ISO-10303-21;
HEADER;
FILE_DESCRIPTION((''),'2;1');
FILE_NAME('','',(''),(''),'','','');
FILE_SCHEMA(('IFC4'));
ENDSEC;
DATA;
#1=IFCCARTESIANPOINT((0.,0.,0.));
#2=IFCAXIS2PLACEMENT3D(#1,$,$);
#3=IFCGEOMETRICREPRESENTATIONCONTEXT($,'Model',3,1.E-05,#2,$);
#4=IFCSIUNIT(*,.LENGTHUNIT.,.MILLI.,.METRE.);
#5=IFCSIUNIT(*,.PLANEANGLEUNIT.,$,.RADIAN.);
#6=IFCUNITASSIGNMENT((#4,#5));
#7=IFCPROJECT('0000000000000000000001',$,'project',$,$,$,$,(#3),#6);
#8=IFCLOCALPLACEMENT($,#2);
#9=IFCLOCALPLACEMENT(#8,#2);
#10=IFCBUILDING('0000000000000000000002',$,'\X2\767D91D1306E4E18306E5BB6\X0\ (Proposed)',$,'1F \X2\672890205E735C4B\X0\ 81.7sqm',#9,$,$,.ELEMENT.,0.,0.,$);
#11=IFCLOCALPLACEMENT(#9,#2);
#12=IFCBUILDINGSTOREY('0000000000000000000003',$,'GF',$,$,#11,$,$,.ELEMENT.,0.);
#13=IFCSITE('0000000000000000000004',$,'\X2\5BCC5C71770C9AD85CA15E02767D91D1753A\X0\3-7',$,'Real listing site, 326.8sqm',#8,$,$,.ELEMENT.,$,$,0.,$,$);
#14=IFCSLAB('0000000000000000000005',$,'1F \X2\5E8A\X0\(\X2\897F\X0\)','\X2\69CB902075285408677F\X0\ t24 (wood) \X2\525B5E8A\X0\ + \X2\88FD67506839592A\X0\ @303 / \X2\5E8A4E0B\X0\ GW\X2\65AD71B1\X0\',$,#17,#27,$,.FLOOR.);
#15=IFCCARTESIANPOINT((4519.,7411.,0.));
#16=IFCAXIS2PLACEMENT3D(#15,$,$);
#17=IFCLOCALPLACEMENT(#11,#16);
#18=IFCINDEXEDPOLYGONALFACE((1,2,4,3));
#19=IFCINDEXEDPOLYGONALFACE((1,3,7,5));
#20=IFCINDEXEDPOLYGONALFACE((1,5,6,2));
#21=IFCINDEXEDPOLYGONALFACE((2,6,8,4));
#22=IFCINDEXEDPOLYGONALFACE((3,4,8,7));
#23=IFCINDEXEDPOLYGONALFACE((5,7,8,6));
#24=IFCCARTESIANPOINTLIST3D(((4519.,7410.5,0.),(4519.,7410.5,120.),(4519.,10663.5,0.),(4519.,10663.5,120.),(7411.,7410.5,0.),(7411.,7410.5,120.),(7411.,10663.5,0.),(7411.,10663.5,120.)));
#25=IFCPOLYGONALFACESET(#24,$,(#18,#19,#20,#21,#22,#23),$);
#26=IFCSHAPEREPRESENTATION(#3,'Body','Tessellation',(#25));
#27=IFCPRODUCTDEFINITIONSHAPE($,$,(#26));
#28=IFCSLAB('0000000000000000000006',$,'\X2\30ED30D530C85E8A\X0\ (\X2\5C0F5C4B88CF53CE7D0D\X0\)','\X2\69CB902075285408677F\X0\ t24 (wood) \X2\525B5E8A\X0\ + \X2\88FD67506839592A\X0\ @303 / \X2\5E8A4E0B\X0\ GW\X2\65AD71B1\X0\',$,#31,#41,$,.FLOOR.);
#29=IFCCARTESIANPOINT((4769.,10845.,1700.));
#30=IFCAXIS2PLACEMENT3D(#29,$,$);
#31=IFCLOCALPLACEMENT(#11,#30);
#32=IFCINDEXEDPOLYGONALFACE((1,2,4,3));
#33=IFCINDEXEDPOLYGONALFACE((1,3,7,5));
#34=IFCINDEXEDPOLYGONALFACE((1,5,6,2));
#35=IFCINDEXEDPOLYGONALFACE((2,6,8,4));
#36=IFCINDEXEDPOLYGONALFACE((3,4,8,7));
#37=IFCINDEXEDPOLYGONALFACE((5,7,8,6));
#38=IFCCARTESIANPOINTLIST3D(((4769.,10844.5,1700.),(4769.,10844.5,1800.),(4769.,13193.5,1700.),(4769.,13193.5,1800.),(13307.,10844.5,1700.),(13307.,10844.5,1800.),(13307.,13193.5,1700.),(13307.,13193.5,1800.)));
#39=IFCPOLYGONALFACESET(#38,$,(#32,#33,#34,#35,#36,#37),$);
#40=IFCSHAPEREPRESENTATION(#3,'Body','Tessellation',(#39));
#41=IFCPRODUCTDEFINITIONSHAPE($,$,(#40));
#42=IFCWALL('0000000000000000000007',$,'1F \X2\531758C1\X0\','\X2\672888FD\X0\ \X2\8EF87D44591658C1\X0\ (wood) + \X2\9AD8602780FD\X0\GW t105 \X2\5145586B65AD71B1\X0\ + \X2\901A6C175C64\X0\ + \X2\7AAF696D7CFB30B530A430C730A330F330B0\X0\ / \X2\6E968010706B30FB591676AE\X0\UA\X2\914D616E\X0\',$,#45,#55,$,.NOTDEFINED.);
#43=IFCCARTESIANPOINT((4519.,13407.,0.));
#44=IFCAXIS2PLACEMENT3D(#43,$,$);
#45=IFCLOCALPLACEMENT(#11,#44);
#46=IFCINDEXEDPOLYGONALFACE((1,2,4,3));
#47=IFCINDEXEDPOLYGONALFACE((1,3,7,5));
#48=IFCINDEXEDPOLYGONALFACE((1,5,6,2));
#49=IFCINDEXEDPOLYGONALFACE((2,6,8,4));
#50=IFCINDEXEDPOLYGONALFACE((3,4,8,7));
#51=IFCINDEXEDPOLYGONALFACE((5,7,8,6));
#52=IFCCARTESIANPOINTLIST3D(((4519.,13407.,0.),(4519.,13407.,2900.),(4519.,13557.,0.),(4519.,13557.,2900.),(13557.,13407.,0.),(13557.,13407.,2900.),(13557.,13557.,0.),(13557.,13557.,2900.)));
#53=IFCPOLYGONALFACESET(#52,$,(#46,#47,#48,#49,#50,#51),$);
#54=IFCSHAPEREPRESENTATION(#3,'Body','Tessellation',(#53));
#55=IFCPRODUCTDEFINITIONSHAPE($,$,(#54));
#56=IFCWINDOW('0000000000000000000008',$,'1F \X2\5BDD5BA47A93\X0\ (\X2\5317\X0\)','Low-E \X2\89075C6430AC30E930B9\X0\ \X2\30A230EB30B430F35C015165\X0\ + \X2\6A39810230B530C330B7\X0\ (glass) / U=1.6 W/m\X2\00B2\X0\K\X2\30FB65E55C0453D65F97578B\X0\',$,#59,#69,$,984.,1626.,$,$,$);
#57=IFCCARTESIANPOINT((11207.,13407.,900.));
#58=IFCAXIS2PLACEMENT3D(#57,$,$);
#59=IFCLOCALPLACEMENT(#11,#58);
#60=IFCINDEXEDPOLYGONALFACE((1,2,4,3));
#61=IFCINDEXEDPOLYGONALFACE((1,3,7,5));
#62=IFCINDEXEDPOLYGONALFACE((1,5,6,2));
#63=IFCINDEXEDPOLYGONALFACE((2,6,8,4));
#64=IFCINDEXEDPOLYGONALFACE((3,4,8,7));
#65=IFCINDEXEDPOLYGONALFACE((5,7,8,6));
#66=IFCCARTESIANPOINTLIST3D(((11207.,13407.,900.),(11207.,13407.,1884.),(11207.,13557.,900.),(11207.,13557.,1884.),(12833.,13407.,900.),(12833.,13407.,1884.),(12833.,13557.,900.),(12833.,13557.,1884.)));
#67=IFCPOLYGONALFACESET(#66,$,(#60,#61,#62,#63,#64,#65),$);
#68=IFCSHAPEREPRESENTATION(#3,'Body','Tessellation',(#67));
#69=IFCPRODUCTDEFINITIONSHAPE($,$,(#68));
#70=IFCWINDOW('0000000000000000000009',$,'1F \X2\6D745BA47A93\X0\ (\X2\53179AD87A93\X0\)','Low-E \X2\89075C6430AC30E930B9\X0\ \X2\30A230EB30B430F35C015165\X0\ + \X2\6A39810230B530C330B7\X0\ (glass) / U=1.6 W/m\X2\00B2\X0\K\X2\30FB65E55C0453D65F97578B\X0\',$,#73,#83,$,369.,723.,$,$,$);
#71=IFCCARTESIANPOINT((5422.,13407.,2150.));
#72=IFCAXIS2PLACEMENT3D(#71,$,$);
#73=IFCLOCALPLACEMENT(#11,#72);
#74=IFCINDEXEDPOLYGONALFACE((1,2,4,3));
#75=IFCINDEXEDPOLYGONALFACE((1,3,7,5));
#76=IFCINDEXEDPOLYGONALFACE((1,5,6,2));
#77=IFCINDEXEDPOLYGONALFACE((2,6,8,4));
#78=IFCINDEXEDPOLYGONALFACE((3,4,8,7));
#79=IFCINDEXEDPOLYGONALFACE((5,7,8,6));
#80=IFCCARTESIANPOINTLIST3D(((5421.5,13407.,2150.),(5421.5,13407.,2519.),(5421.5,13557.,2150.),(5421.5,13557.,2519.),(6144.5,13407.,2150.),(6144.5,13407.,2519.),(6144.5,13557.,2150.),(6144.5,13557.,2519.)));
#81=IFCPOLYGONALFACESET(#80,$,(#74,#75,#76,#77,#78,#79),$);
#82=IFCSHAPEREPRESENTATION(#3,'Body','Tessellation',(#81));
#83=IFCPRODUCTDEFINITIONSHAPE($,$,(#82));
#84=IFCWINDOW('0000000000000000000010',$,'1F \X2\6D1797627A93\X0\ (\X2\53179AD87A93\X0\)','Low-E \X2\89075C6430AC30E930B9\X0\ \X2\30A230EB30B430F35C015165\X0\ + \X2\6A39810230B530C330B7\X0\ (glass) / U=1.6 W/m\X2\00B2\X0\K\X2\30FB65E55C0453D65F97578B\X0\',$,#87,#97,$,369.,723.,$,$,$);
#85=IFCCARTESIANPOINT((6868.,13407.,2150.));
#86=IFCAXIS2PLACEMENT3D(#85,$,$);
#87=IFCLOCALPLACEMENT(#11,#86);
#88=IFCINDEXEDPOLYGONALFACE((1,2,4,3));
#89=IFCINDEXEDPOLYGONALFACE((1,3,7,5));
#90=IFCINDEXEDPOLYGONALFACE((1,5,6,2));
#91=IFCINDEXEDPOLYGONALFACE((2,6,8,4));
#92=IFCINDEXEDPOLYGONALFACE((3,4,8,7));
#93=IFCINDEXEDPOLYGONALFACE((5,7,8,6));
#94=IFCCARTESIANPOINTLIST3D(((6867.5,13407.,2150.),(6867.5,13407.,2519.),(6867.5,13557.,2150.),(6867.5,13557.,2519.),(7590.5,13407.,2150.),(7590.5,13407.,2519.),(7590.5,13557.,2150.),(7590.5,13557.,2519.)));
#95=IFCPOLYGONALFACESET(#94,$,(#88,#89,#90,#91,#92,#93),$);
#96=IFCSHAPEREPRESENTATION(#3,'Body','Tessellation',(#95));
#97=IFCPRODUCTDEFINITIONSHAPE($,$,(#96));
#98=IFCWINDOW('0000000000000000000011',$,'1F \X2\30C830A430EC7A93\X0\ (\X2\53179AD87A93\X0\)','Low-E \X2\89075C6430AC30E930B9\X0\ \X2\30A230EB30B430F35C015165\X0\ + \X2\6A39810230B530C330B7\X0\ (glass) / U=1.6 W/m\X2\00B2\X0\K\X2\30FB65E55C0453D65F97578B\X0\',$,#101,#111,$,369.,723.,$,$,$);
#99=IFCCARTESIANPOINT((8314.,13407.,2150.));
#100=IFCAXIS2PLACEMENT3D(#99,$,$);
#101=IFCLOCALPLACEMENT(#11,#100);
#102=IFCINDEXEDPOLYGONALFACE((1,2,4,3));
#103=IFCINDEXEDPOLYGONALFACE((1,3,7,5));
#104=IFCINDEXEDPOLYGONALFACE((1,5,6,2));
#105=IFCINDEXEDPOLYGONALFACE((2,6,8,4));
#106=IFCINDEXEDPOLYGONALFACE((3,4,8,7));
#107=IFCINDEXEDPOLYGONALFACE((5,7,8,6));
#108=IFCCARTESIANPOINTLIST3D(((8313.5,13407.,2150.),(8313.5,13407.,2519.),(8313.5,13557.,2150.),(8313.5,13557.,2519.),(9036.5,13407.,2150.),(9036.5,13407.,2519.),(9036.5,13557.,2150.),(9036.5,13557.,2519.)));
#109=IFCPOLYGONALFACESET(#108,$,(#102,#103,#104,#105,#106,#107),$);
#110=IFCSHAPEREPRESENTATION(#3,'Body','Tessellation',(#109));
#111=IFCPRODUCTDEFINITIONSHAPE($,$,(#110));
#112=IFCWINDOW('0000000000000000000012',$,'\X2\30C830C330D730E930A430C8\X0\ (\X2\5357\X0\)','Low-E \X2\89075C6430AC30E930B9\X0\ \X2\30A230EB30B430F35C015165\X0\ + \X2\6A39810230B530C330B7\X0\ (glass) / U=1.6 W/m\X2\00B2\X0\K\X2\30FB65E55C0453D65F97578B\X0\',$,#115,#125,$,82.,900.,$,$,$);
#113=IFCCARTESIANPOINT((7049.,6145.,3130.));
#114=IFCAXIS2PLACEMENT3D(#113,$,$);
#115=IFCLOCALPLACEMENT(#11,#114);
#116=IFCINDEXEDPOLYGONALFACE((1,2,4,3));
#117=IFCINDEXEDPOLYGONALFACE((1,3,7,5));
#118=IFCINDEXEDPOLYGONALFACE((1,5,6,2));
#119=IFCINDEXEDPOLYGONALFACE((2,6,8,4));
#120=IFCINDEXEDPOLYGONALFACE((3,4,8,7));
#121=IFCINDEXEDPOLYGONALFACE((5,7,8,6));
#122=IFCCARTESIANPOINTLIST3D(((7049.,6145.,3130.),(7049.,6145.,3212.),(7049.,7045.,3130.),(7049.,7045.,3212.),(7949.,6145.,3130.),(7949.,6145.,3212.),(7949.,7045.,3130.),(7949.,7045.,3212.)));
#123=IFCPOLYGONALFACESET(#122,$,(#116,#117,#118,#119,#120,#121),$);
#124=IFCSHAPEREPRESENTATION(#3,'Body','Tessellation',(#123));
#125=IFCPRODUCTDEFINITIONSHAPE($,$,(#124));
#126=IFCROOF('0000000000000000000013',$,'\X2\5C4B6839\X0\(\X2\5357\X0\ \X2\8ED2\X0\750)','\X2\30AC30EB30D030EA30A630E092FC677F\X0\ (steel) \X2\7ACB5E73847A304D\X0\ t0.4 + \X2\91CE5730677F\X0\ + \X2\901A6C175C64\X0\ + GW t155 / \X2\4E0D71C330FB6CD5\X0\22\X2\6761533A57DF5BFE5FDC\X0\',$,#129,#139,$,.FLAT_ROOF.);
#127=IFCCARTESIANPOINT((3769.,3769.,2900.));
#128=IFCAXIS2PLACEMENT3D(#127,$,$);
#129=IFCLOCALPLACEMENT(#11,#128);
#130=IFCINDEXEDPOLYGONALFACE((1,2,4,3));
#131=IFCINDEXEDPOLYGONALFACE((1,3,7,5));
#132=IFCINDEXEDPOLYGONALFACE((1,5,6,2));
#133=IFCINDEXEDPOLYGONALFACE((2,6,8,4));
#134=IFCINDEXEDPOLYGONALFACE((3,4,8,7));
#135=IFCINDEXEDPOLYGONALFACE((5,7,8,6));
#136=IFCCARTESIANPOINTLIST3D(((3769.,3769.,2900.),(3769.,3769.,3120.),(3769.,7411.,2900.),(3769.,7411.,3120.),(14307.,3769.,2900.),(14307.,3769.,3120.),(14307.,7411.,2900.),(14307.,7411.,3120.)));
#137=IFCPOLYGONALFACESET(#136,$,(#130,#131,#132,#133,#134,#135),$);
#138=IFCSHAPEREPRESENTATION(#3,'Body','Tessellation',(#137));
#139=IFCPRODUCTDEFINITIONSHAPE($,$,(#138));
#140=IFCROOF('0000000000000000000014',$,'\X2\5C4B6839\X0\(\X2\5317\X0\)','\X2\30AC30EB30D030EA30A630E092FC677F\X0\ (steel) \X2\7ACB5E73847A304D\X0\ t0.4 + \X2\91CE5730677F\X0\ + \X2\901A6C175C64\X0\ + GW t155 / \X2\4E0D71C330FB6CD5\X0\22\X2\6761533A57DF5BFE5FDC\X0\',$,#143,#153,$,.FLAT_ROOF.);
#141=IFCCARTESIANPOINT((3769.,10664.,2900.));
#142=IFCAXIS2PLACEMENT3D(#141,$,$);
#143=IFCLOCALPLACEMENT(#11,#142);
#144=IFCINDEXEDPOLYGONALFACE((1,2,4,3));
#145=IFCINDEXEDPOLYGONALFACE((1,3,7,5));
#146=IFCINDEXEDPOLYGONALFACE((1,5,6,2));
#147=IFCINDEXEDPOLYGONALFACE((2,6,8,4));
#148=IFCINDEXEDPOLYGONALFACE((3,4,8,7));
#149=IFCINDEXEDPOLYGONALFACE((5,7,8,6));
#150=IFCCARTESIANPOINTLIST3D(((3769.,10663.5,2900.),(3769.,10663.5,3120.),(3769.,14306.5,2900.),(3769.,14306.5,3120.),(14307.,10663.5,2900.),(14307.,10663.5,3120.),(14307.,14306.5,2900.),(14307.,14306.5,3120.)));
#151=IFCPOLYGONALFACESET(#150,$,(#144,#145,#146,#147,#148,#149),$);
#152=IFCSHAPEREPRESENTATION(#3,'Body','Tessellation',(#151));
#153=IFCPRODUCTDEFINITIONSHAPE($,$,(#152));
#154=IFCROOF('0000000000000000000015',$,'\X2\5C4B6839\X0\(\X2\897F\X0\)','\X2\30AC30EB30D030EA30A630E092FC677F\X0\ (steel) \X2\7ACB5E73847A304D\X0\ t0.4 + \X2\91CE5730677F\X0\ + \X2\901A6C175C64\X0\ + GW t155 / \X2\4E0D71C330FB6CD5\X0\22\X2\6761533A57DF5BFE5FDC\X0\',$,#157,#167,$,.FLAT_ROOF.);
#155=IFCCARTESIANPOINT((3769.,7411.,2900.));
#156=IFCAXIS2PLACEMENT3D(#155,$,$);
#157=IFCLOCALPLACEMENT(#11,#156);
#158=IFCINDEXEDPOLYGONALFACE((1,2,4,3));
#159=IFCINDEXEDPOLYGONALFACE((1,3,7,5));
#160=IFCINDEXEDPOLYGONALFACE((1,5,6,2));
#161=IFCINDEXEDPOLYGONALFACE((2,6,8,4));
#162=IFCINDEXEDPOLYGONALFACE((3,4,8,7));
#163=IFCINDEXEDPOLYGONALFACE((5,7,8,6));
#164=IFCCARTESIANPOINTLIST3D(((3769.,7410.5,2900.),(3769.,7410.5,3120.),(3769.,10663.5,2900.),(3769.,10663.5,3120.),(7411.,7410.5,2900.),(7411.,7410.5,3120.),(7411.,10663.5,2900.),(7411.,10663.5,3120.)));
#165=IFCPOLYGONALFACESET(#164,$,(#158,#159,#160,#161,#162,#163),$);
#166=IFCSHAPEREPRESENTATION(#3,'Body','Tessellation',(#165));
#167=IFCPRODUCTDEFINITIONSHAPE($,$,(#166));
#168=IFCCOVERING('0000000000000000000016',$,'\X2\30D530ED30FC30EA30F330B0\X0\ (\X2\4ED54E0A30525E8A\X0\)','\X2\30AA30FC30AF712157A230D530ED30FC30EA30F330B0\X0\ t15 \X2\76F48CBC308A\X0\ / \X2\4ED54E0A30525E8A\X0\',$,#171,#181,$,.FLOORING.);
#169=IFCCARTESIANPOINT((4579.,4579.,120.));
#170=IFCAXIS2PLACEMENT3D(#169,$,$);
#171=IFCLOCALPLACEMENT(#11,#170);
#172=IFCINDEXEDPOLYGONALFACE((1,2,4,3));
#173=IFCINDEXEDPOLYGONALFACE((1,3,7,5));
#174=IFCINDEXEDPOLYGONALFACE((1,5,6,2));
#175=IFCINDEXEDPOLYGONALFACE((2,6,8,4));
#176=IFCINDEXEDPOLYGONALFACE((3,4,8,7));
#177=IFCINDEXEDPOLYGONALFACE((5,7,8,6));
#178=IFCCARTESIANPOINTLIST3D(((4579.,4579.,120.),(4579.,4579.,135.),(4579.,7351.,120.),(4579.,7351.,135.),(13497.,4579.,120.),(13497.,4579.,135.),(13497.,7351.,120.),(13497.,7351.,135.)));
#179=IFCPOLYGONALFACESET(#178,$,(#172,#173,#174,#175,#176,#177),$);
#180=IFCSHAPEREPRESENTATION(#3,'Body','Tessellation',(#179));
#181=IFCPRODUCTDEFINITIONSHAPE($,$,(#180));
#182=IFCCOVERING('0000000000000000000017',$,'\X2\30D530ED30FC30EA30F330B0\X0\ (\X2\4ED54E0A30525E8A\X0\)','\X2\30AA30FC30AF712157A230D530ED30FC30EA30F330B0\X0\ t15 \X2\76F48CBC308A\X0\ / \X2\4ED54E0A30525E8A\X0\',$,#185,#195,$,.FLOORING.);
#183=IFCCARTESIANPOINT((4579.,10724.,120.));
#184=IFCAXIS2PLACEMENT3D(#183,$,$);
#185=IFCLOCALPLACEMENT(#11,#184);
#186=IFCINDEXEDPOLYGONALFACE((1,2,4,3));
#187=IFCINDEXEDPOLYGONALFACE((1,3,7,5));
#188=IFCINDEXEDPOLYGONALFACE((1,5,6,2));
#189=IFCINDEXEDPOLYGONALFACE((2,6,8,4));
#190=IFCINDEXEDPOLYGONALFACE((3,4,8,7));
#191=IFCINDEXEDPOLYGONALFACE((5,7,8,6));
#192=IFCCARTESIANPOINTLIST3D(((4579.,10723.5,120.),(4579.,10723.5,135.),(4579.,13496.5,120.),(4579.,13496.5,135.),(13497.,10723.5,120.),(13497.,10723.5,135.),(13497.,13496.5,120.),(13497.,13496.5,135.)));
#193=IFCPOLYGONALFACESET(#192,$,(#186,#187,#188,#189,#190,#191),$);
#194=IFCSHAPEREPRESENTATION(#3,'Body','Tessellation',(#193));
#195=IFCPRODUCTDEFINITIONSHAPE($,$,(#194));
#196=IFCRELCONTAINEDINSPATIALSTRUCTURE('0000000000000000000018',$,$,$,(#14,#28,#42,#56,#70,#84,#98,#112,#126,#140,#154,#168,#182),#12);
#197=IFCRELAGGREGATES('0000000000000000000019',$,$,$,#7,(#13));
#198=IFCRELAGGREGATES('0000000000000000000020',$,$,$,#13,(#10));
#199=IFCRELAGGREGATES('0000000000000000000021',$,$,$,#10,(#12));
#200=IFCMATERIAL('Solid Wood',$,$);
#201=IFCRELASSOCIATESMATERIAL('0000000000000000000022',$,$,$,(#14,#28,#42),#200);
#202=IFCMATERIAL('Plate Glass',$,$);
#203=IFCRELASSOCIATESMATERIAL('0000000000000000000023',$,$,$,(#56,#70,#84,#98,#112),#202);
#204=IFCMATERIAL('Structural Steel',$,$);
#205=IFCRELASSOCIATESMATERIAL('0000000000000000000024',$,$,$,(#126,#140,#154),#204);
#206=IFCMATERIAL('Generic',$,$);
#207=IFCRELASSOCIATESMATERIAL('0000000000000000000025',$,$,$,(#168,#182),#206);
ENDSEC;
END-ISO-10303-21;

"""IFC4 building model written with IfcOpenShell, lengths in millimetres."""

from ifc_helpers import new_model, si_unit, frame, frame_2d, origin, place, context, project, spatial, rectangle, extrude, material, element, fill, save


model = new_model("IFC4")

# Units and contexts
model_context = context("Model", 3, precision=1e-05, world=origin())
ifc_project = project(units=[si_unit("LENGTHUNIT", "METRE", prefix="MILLI"), si_unit("PLANEANGLEUNIT", "RADIAN")], contexts=[model_context])

# Site, building, storey
site_placement = place(None, origin())
site = spatial("IfcSite", under=ifc_project, at=site_placement, Name="富山県高岡市白金町3-7", ObjectType="Real listing site, 326.8sqm", CompositionType="ELEMENT", RefElevation=0.0)
building_placement = place(site_placement, origin())
building = spatial("IfcBuilding", under=site, at=building_placement, Name="白金の丘の家 (Proposed)", ObjectType="1F 木造平屋 81.7sqm", CompositionType="ELEMENT", ElevationOfRefHeight=0.0, ElevationOfTerrain=0.0)
storey_placement = place(building_placement, origin())
storey = spatial("IfcBuildingStorey", under=building, at=storey_placement, Name="GF", CompositionType="ELEMENT", Elevation=0.0)

# Slabs
ifc_material_1 = material(Name="Solid Wood")
slab_1_placement = place(storey_placement, frame((4519.0, 7411.0, 0.0)))
element("IfcSlab", 1, at=slab_1_placement, inside=storey, material=ifc_material_1, Name="1F 床(西)", Description="構造用合板 t24 (wood) 剛床 + 製材根太 @303 / 床下 GW断熱", PredefinedType="FLOOR", context=model_context, shape_type="SweptSolid", body=[
    extrude(rectangle(XDim=2892.0, YDim=3253.0, at=frame_2d((1446.0, 1626.0))), frame((4519.0, 7411.0, 0.0)), (0.0, 0.0, 1.0), 120.0),
])
slab_2_placement = place(storey_placement, frame((4769.0, 10845.0, 1700.0)))
element("IfcSlab", 2, at=slab_2_placement, inside=storey, material=ifc_material_1, Name="ロフト床 (小屋裏収納)", Description="構造用合板 t24 (wood) 剛床 + 製材根太 @303 / 床下 GW断熱", PredefinedType="FLOOR", context=model_context, shape_type="SweptSolid", body=[
    extrude(rectangle(XDim=8538.0, YDim=2349.0, at=frame_2d((4269.0, 1174.0))), frame((4769.0, 10845.0, 1700.0)), (0.0, 0.0, 1.0), 100.0),
])

# Shared definitions
ifc_material_2 = material(Name="Plate Glass")

# Wall, openings, windows
wall_1_placement = place(storey_placement, frame((4519.0, 13407.0, 0.0)))
wall_1 = element("IfcWall", 3, at=wall_1_placement, inside=storey, material=ifc_material_1, Name="1F 北壁", Description="木製 軸組外壁 (wood) + 高性能GW t105 充填断熱 + 通気層 + 窯業系サイディング / 準耐火・外皮UA配慮", PredefinedType="NOTDEFINED", context=model_context, shape_type="SweptSolid", body=[
    extrude(rectangle(XDim=9038.0, YDim=150.0, at=frame_2d((4519.0, 75.0))), frame((4519.0, 13407.0, 0.0)), (0.0, 0.0, 1.0), 2900.0),
])
opening_1_placement = place(storey_placement, frame((11207.0, 13407.0, 900.0)))
opening_1 = element("IfcOpeningElement", 4, at=opening_1_placement, cuts=wall_1, PredefinedType="NOTDEFINED", context=model_context, shape_type="SweptSolid", body=[
    extrude(rectangle(XDim=1626.0, YDim=150.0, at=frame_2d((813.0, 75.0))), frame((11207.0, 13407.0, 900.0)), (0.0, 0.0, 1.0), 984.0),
])
opening_2_placement = place(storey_placement, frame((5422.0, 13407.0, 2150.0)))
opening_2 = element("IfcOpeningElement", 5, at=opening_2_placement, cuts=wall_1, PredefinedType="NOTDEFINED", context=model_context, shape_type="SweptSolid", body=[
    extrude(rectangle(XDim=723.0, YDim=150.0, at=frame_2d((361.0, 75.0))), frame((5422.0, 13407.0, 2150.0)), (0.0, 0.0, 1.0), 369.0),
])
opening_3_placement = place(storey_placement, frame((6868.0, 13407.0, 2150.0)))
opening_3 = element("IfcOpeningElement", 6, at=opening_3_placement, cuts=wall_1, PredefinedType="NOTDEFINED", context=model_context, shape_type="SweptSolid", body=[
    extrude(rectangle(XDim=723.0, YDim=150.0, at=frame_2d((361.0, 75.0))), frame((6868.0, 13407.0, 2150.0)), (0.0, 0.0, 1.0), 369.0),
])
opening_4_placement = place(storey_placement, frame((8314.0, 13407.0, 2150.0)))
opening_4 = element("IfcOpeningElement", 7, at=opening_4_placement, cuts=wall_1, PredefinedType="NOTDEFINED", context=model_context, shape_type="SweptSolid", body=[
    extrude(rectangle(XDim=723.0, YDim=150.0, at=frame_2d((361.0, 75.0))), frame((8314.0, 13407.0, 2150.0)), (0.0, 0.0, 1.0), 369.0),
])
window_1_placement = place(storey_placement, frame((11207.0, 13407.0, 900.0)))
window_1 = element("IfcWindow", 8, at=window_1_placement, inside=storey, material=ifc_material_2, Name="1F 寝室窓 (北)", Description="Low-E 複層ガラス アルゴン封入 + 樹脂サッシ (glass) / U=1.6 W/m²K・日射取得型", OverallHeight=984.0, OverallWidth=1626.0, context=model_context, shape_type="SweptSolid", body=[
    extrude(rectangle(XDim=1626.0, YDim=150.0, at=frame_2d((813.0, 75.0))), frame((11207.0, 13407.0, 900.0)), (0.0, 0.0, 1.0), 984.0),
])
fill(opening_1, window_1)
window_2_placement = place(storey_placement, frame((5422.0, 13407.0, 2150.0)))
window_2 = element("IfcWindow", 9, at=window_2_placement, inside=storey, material=ifc_material_2, Name="1F 浴室窓 (北高窓)", Description="Low-E 複層ガラス アルゴン封入 + 樹脂サッシ (glass) / U=1.6 W/m²K・日射取得型", OverallHeight=369.0, OverallWidth=723.0, context=model_context, shape_type="SweptSolid", body=[
    extrude(rectangle(XDim=723.0, YDim=150.0, at=frame_2d((361.0, 75.0))), frame((5422.0, 13407.0, 2150.0)), (0.0, 0.0, 1.0), 369.0),
])
fill(opening_2, window_2)
window_3_placement = place(storey_placement, frame((6868.0, 13407.0, 2150.0)))
window_3 = element("IfcWindow", 10, at=window_3_placement, inside=storey, material=ifc_material_2, Name="1F 洗面窓 (北高窓)", Description="Low-E 複層ガラス アルゴン封入 + 樹脂サッシ (glass) / U=1.6 W/m²K・日射取得型", OverallHeight=369.0, OverallWidth=723.0, context=model_context, shape_type="SweptSolid", body=[
    extrude(rectangle(XDim=723.0, YDim=150.0, at=frame_2d((361.0, 75.0))), frame((6868.0, 13407.0, 2150.0)), (0.0, 0.0, 1.0), 369.0),
])
fill(opening_3, window_3)
window_4_placement = place(storey_placement, frame((8314.0, 13407.0, 2150.0)))
window_4 = element("IfcWindow", 11, at=window_4_placement, inside=storey, material=ifc_material_2, Name="1F トイレ窓 (北高窓)", Description="Low-E 複層ガラス アルゴン封入 + 樹脂サッシ (glass) / U=1.6 W/m²K・日射取得型", OverallHeight=369.0, OverallWidth=723.0, context=model_context, shape_type="SweptSolid", body=[
    extrude(rectangle(XDim=723.0, YDim=150.0, at=frame_2d((361.0, 75.0))), frame((8314.0, 13407.0, 2150.0)), (0.0, 0.0, 1.0), 369.0),
])
fill(opening_4, window_4)

# Window
window_5_placement = place(storey_placement, frame((7049.0, 6145.0, 3130.0)))
element("IfcWindow", 12, at=window_5_placement, inside=storey, material=ifc_material_2, Name="トップライト (南)", Description="Low-E 複層ガラス アルゴン封入 + 樹脂サッシ (glass) / U=1.6 W/m²K・日射取得型", OverallHeight=82.0, OverallWidth=900.0, context=model_context, shape_type="SweptSolid", body=[
    extrude(rectangle(XDim=900.0, YDim=900.0, at=frame_2d((450.0, 450.0))), frame((7049.0, 6145.0, 3130.0)), (0.0, 0.0, 1.0), 82.0),
])

# Roofs
ifc_material_3 = material(Name="Structural Steel")
roof_1_placement = place(storey_placement, frame((3769.0, 3769.0, 2900.0)))
element("IfcRoof", 13, at=roof_1_placement, inside=storey, material=ifc_material_3, Name="屋根(南 軒750)", Description="ガルバリウム鋼板 (steel) 立平葺き t0.4 + 野地板 + 通気層 + GW t155 / 不燃・法22条区域対応", PredefinedType="FLAT_ROOF", context=model_context, shape_type="SweptSolid", body=[
    extrude(rectangle(XDim=10538.0, YDim=3642.0, at=frame_2d((5269.0, 1821.0))), frame((3769.0, 3769.0, 2900.0)), (0.0, 0.0, 1.0), 220.0),
])
roof_2_placement = place(storey_placement, frame((3769.0, 10664.0, 2900.0)))
element("IfcRoof", 14, at=roof_2_placement, inside=storey, material=ifc_material_3, Name="屋根(北)", Description="ガルバリウム鋼板 (steel) 立平葺き t0.4 + 野地板 + 通気層 + GW t155 / 不燃・法22条区域対応", PredefinedType="FLAT_ROOF", context=model_context, shape_type="SweptSolid", body=[
    extrude(rectangle(XDim=10538.0, YDim=3643.0, at=frame_2d((5269.0, 1821.0))), frame((3769.0, 10664.0, 2900.0)), (0.0, 0.0, 1.0), 220.0),
])
roof_3_placement = place(storey_placement, frame((3769.0, 7411.0, 2900.0)))
element("IfcRoof", 15, at=roof_3_placement, inside=storey, material=ifc_material_3, Name="屋根(西)", Description="ガルバリウム鋼板 (steel) 立平葺き t0.4 + 野地板 + 通気層 + GW t155 / 不燃・法22条区域対応", PredefinedType="FLAT_ROOF", context=model_context, shape_type="SweptSolid", body=[
    extrude(rectangle(XDim=3642.0, YDim=3253.0, at=frame_2d((1821.0, 1626.0))), frame((3769.0, 7411.0, 2900.0)), (0.0, 0.0, 1.0), 220.0),
])

# Coverings
ifc_material_4 = material(Name="Generic")
covering_1_placement = place(storey_placement, frame((4579.0, 4579.0, 120.0)))
element("IfcCovering", 16, at=covering_1_placement, inside=storey, material=ifc_material_4, Name="フローリング (仕上げ床)", Description="オーク無垢フローリング t15 直貼り / 仕上げ床", PredefinedType="FLOORING", context=model_context, shape_type="SweptSolid", body=[
    extrude(rectangle(XDim=8918.0, YDim=2772.0, at=frame_2d((4459.0, 1386.0))), frame((4579.0, 4579.0, 120.0)), (0.0, 0.0, 1.0), 15.0),
])
covering_2_placement = place(storey_placement, frame((4579.0, 10724.0, 120.0)))
element("IfcCovering", 17, at=covering_2_placement, inside=storey, material=ifc_material_4, Name="フローリング (仕上げ床)", Description="オーク無垢フローリング t15 直貼り / 仕上げ床", PredefinedType="FLOORING", context=model_context, shape_type="SweptSolid", body=[
    extrude(rectangle(XDim=8918.0, YDim=2773.0, at=frame_2d((4459.0, 1386.0))), frame((4579.0, 10724.0, 120.0)), (0.0, 0.0, 1.0), 15.0),
])

save(model, "model.ifc")
